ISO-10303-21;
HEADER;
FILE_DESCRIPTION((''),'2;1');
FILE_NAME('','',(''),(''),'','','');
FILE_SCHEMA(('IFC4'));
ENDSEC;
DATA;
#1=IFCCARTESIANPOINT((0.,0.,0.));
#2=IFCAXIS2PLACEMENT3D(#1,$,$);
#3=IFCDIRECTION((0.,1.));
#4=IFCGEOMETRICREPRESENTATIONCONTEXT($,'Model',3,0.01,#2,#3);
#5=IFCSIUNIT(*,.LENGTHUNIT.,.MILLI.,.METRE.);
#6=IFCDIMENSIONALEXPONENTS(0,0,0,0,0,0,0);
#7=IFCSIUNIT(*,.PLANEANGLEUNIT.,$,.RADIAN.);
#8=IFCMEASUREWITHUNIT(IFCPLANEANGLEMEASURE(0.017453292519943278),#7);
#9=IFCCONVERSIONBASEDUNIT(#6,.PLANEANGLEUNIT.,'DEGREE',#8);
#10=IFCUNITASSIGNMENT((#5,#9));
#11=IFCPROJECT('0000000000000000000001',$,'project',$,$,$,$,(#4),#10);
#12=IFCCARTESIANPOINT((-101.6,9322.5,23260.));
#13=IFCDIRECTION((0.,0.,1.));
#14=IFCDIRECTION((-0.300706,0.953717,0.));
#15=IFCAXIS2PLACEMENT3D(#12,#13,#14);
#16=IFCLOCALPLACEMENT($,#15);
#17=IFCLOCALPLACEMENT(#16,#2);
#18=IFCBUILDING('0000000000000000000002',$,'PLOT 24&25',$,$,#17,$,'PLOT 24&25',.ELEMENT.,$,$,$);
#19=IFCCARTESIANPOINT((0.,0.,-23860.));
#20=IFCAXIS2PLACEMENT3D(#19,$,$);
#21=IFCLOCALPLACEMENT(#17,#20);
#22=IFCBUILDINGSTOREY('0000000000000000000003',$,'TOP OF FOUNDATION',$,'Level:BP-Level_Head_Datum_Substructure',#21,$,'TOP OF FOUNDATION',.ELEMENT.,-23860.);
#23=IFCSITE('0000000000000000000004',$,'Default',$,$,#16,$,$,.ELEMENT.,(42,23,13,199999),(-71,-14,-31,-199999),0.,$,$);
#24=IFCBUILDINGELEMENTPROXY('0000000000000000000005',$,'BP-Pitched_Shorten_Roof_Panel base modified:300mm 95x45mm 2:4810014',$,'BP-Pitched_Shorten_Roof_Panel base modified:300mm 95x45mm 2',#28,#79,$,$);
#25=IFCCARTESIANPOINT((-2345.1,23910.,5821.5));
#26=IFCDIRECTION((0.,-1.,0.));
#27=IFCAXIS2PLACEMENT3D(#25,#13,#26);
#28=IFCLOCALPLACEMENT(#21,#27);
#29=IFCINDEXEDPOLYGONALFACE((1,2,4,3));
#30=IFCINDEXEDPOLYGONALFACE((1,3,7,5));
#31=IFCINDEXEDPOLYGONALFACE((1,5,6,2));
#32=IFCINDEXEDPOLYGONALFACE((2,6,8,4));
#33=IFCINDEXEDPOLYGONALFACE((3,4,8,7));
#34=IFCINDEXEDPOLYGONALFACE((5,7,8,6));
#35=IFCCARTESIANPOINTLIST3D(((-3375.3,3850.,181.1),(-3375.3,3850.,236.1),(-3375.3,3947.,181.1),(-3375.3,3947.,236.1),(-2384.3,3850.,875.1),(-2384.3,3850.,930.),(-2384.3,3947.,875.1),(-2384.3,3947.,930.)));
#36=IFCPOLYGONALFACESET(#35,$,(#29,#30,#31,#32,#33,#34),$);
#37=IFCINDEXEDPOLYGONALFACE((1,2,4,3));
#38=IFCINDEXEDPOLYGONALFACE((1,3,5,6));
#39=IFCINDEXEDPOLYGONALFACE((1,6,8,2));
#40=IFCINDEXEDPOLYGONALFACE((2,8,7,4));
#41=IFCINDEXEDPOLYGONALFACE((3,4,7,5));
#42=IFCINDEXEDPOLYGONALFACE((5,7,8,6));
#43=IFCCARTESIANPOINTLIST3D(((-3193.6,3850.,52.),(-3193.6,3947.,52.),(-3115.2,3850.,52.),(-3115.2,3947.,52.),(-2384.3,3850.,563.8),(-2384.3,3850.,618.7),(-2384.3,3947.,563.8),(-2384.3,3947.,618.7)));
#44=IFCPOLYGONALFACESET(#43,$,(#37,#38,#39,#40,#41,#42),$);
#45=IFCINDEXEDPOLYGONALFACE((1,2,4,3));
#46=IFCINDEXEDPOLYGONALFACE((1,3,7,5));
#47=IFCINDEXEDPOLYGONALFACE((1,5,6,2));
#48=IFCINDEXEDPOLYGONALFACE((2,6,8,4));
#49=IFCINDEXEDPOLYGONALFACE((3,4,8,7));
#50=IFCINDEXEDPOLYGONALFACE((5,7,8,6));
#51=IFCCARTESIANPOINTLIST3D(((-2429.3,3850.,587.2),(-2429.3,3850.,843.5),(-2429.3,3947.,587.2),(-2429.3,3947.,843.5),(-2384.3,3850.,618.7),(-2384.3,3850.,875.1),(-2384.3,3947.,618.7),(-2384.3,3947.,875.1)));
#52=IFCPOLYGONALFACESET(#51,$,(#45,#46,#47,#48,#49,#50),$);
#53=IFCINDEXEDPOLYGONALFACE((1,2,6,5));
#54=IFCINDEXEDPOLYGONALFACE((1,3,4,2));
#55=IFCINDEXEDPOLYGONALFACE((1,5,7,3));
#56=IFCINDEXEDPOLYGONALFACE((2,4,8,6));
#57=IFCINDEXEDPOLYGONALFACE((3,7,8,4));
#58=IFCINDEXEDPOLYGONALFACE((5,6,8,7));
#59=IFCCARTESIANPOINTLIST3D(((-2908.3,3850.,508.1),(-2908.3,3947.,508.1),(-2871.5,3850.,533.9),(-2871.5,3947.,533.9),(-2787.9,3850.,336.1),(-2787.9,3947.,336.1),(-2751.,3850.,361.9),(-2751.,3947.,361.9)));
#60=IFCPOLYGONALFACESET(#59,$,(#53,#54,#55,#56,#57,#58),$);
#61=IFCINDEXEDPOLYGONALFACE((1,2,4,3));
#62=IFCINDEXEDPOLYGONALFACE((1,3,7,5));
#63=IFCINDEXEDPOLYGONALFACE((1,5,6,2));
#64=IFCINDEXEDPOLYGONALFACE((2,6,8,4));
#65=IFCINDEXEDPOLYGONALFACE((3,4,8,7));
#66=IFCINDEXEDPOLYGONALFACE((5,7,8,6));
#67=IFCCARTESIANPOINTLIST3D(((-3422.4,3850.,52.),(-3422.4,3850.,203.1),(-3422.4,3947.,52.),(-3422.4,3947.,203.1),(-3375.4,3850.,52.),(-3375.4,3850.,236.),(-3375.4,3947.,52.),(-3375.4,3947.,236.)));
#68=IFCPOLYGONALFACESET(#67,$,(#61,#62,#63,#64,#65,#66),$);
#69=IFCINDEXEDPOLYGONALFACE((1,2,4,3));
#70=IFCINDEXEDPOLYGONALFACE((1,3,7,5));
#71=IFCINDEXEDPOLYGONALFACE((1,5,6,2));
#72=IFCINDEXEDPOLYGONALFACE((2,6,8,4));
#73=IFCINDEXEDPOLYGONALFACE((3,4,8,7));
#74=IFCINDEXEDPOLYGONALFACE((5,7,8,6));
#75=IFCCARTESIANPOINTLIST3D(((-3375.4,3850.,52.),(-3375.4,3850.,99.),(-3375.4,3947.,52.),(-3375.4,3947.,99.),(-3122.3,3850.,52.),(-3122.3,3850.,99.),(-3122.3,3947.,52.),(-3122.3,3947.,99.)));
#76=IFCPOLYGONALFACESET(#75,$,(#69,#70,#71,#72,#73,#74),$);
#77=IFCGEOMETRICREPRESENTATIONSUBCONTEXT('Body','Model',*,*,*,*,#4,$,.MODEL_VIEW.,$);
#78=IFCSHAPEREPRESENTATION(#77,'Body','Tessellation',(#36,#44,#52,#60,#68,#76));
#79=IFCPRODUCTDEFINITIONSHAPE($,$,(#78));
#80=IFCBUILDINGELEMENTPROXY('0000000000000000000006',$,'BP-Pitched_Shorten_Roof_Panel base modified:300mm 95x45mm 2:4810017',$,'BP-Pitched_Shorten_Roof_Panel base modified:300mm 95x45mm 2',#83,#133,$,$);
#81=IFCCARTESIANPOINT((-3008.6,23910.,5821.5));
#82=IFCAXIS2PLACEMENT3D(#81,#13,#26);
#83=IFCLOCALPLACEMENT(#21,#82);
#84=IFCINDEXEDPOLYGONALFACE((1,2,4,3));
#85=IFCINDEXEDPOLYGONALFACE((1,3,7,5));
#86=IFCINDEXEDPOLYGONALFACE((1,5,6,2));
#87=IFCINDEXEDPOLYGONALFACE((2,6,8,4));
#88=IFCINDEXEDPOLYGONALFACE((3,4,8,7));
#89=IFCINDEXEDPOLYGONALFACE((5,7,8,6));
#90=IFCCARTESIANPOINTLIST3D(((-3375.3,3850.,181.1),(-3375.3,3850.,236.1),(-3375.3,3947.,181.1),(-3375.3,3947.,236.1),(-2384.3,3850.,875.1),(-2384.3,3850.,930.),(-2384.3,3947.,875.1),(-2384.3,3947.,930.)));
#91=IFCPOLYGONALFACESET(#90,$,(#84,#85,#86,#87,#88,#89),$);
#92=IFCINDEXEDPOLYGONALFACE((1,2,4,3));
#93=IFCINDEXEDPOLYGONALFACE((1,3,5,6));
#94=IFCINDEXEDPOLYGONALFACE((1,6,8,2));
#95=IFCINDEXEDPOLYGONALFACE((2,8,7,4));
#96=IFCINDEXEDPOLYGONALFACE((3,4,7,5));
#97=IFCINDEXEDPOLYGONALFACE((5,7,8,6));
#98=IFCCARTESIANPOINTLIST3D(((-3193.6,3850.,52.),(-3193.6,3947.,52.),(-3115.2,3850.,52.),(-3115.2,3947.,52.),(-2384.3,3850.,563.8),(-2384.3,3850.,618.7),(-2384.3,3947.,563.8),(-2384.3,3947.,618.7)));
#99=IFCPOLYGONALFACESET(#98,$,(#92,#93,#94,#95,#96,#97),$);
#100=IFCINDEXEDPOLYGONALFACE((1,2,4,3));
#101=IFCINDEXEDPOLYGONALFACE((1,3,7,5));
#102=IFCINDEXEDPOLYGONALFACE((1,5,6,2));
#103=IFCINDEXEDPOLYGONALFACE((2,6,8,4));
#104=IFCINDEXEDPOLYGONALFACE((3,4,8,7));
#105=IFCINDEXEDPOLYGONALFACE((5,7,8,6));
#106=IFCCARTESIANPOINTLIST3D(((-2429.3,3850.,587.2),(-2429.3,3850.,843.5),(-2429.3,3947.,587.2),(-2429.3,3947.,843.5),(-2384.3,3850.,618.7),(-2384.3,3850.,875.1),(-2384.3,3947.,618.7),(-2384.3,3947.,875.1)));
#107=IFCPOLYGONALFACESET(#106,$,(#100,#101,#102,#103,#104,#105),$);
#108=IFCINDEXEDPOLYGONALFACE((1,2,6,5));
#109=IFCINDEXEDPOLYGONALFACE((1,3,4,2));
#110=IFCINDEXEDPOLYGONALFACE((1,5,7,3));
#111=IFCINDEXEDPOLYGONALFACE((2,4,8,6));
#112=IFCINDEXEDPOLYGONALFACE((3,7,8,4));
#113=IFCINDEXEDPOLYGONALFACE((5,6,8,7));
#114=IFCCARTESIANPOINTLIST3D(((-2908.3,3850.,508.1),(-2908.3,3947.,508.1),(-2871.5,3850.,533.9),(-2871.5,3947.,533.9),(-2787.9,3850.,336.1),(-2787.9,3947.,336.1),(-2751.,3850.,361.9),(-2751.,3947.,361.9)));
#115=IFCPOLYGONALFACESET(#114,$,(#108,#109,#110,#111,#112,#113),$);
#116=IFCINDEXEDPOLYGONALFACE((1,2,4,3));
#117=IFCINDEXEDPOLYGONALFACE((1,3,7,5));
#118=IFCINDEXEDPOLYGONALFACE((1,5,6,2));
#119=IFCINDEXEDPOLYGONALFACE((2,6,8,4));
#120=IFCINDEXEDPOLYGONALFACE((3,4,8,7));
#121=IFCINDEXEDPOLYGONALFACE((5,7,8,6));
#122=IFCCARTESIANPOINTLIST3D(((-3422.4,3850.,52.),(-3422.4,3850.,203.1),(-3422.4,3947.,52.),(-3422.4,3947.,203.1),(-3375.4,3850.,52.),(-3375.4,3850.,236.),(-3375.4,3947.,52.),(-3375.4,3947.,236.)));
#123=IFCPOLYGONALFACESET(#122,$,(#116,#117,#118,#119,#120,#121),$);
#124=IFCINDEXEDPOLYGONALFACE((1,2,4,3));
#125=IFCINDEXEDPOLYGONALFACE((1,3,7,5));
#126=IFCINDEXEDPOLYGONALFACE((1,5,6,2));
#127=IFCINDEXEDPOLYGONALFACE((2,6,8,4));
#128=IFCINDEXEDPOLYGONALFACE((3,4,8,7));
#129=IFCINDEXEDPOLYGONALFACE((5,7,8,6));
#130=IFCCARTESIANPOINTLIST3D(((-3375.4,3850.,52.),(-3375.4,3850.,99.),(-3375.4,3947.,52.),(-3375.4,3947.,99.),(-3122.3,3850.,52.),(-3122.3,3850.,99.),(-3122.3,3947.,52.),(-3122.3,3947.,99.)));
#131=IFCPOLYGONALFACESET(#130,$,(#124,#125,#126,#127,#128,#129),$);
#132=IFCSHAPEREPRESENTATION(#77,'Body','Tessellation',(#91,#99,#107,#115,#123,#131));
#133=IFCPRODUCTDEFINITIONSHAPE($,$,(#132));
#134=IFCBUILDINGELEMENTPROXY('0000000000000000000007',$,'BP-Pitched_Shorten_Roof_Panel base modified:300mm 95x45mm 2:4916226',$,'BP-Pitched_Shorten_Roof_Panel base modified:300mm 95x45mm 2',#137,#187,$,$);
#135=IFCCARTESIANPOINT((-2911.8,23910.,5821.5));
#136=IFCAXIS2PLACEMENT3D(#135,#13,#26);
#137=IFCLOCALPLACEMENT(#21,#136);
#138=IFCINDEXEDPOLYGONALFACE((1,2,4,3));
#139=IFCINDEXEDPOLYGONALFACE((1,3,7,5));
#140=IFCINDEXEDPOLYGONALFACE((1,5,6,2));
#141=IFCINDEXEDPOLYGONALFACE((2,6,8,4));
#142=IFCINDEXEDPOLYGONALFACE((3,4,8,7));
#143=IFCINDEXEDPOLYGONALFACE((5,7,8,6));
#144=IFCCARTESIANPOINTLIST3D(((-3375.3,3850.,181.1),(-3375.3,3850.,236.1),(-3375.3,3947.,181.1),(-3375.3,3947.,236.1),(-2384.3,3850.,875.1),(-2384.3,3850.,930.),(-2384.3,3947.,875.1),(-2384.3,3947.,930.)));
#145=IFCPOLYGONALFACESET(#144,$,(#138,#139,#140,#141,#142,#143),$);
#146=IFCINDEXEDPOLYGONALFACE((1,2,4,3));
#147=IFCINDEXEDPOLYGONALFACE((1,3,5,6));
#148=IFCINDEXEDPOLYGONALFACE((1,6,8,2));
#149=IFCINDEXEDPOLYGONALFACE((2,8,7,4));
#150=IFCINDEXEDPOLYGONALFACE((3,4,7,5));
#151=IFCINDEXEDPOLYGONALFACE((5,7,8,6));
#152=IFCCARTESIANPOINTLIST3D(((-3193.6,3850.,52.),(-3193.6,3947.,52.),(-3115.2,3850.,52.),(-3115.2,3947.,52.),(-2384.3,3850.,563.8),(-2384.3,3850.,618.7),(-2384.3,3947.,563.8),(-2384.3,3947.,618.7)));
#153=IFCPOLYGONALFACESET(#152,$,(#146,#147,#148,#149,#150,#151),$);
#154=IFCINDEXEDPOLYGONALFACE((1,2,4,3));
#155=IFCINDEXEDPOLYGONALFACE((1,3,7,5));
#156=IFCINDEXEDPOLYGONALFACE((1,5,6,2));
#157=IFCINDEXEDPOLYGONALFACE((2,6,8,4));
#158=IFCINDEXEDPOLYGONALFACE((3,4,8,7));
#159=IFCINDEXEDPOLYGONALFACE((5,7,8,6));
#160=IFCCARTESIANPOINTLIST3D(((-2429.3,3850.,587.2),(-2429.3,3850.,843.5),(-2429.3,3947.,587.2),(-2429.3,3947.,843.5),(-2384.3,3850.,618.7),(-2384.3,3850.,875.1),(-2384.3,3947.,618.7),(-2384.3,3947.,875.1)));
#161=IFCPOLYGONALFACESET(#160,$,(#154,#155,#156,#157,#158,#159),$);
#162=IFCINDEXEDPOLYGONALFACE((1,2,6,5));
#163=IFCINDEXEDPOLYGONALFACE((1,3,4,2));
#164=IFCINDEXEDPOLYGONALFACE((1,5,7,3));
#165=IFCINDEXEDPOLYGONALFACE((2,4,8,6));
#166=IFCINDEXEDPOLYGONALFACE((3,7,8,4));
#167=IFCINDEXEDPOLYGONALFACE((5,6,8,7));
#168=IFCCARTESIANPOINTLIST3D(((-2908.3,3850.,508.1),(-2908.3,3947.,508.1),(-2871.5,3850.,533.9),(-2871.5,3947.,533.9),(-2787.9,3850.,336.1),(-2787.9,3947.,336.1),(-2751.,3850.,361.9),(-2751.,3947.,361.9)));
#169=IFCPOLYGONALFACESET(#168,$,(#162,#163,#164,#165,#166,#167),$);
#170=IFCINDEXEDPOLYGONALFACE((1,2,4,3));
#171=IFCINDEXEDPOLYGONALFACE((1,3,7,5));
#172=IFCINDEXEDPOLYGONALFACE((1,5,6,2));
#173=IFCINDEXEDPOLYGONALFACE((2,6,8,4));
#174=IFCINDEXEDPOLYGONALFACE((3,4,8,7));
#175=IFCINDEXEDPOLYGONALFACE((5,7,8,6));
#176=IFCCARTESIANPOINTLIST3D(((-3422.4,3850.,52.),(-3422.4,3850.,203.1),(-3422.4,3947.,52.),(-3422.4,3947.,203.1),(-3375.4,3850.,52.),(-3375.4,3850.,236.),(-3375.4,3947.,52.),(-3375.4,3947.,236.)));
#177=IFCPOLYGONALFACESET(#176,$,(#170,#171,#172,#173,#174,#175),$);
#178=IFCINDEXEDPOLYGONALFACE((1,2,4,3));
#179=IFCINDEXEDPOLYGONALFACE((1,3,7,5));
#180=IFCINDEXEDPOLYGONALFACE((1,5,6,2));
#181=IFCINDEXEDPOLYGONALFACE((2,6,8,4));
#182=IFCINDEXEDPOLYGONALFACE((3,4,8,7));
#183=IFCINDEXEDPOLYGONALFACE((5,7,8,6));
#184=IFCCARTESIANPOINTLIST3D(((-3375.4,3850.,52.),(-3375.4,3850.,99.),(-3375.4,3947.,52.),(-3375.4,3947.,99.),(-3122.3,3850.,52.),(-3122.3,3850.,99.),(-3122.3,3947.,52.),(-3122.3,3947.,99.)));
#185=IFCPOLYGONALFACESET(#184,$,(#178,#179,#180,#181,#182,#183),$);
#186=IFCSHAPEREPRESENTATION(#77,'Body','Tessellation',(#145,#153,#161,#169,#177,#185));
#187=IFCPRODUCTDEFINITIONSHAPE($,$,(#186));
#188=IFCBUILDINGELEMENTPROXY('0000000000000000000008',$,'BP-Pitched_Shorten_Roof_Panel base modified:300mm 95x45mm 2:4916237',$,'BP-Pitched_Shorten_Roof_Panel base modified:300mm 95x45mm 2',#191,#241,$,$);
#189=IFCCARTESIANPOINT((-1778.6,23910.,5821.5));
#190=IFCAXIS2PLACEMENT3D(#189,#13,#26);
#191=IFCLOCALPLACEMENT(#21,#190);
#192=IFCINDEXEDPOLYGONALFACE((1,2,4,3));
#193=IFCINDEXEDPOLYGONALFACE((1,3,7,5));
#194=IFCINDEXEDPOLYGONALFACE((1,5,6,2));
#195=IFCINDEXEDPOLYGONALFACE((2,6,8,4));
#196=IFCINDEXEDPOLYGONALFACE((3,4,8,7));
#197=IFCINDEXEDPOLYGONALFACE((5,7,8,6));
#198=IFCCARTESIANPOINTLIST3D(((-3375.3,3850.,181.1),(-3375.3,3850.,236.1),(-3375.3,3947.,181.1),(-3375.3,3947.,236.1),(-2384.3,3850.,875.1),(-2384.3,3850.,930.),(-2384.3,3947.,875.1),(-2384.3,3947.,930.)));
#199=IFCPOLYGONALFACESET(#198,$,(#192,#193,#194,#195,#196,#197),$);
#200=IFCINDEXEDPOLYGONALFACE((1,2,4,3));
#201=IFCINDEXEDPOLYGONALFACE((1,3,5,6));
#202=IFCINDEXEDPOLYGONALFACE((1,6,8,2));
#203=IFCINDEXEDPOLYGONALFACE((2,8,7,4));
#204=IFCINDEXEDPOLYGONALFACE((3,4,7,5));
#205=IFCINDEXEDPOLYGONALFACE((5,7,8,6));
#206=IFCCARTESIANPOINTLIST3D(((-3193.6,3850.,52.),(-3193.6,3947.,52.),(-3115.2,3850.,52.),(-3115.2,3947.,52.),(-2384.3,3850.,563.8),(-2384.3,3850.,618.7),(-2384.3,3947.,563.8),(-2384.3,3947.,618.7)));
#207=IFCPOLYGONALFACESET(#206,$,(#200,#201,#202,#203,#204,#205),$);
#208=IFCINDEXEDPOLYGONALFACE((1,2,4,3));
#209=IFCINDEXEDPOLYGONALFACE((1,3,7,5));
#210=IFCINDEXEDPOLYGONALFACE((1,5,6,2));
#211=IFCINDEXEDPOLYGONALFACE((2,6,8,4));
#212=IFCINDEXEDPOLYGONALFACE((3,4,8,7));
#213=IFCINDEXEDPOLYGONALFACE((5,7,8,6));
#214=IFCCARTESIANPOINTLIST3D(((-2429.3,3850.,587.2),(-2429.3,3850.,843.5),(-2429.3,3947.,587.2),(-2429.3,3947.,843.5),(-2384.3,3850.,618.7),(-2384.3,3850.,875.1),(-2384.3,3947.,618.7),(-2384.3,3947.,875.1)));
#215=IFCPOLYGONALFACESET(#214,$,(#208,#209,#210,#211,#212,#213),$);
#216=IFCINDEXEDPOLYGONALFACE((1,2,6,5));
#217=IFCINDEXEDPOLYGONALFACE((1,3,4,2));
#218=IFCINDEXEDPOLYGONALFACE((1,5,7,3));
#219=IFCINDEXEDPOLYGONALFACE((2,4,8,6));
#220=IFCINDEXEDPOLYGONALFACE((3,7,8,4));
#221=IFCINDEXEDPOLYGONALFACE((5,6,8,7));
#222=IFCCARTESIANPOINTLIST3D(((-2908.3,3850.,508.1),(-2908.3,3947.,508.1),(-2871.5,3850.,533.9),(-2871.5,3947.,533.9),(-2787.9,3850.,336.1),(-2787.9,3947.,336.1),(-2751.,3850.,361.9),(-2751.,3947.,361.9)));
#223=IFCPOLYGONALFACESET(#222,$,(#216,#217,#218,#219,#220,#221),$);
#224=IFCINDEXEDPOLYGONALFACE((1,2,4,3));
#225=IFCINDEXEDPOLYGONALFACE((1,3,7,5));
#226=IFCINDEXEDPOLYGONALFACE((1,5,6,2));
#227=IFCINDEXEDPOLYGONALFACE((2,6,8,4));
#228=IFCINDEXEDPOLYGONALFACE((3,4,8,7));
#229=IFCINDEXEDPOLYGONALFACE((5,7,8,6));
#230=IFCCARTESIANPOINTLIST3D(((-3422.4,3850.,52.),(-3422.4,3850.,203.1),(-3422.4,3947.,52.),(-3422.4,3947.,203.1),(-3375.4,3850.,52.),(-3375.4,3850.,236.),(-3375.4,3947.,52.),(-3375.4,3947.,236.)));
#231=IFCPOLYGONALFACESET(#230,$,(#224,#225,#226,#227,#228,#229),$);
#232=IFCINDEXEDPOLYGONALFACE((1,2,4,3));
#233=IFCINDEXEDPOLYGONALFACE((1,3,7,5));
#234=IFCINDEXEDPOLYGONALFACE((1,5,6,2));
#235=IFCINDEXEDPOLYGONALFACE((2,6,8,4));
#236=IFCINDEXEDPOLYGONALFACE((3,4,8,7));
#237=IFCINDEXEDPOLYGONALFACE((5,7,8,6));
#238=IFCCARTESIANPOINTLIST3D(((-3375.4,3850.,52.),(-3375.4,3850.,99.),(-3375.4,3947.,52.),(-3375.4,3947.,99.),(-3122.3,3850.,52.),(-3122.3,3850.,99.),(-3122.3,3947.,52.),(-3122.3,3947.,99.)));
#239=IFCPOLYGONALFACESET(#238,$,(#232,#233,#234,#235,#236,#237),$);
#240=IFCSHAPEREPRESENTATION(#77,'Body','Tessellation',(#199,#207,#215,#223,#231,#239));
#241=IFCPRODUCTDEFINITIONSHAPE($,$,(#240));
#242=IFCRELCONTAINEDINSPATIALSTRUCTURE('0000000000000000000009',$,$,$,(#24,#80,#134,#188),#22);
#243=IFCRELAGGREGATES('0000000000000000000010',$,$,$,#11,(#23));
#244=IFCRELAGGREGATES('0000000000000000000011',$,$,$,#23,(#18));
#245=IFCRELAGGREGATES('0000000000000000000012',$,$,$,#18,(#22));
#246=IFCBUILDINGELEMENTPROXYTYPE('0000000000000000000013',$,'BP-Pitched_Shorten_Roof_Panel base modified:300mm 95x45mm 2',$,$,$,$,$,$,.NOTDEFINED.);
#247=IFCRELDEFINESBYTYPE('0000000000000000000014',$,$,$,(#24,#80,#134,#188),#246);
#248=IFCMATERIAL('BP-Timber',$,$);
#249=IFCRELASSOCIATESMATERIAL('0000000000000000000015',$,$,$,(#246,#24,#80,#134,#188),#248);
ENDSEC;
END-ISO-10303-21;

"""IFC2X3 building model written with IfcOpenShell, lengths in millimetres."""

from ifc_helpers import new_model, entity, si_unit, converted_unit, direction, frame, frame_2d, origin, place, context, subcontext, project, spatial, polyline, rectangle, outline, extrude, source, transform, mapped, material, type_object, type_shapes, element, save


model = new_model("IFC2X3")

# Units and contexts
model_context = context("Model", 3, precision=0.01, world=origin(), true_north=direction((0.0, 1.0)))
body_context = subcontext(model_context, "Body", "Model", "MODEL_VIEW")
ifc_project = project(units=[si_unit("LENGTHUNIT", "METRE", prefix="MILLI"), converted_unit("PLANEANGLEUNIT", "DEGREE", entity("IfcPlaneAngleMeasure", 0.017453292519943278), si_unit("PLANEANGLEUNIT", "RADIAN"), dimensions=[0, 0, 0, 0, 0, 0, 0])], contexts=[model_context])

# Site, building, storey
site_placement = place(None, frame((-101.6, 9322.5, 23260.0), z_axis=(0.0, 0.0, 1.0), x_axis=(-0.300706, 0.953717, 0.0)))
site = spatial("IfcSite", under=ifc_project, at=site_placement, Name="Default", CompositionType="ELEMENT", RefLatitude=(42, 23, 13, 199999), RefLongitude=(-71, -14, -31, -199999), RefElevation=0.0)
building_placement = place(site_placement, origin())
building = spatial("IfcBuilding", under=site, at=building_placement, Name="PLOT 24&25", LongName="PLOT 24&25", CompositionType="ELEMENT")
storey_placement = place(building_placement, frame((0.0, 0.0, -23860.0)))
storey = spatial("IfcBuildingStorey", under=building, at=storey_placement, Name="TOP OF FOUNDATION", ObjectType="Level:BP-Level_Head_Datum_Substructure", LongName="TOP OF FOUNDATION", CompositionType="ELEMENT", Elevation=-23860.0)

# Building element proxies
ifc_material_1 = material(Name="BP-Timber")
building_element_proxy_type_1 = type_object("IfcBuildingElementProxyType", Name="BP-Pitched_Shorten_Roof_Panel base modified:300mm 95x45mm 2", PredefinedType="NOTDEFINED", material=ifc_material_1)
shared_shape_1 = source(origin(), body_context, "Body", "SweptSolid", [
    extrude(outline(polyline([(-374.4, -495.5), (-319.5, -495.5), (374.4, 495.5), (319.5, 495.5), (-374.4, -495.5)])), frame((-2879.8, 3850.0, 555.6), z_axis=(0.0, 1.0, 0.0), x_axis=(0.0, 0.0, -1.0)), (0.0, 0.0, 1.0), 97.0),
    extrude(outline(polyline([(-297.1, -385.0), (-242.1, -385.0), (269.6, 345.8), (269.6, 424.3), (-297.1, -385.0)])), frame((-2769.4, 3850.0, 321.6), z_axis=(0.0, 1.0, 0.0), x_axis=(0.0, 0.0, -1.0)), (0.0, 0.0, 1.0), 97.0),
    extrude(outline(polyline([(46.1, -105.0), (101.0, -105.0), (-46.1, 105.0), (-101.0, 105.0), (46.1, -105.0)])), frame((-2406.8, 3850.0, 731.1), z_axis=(0.0, 1.0, 0.0), x_axis=(0.819152, 0.0, 0.573576)), (0.0, 0.0, 1.0), 97.0),
    extrude(rectangle(XDim=45.0, YDim=97.0, at=frame_2d((0.0, 0.0), x_axis=(0.0, 1.0))), frame((-2769.5, 3898.5, 349.0), z_axis=(-0.573576, 0.0, 0.819152), x_axis=(0.0, 1.0, 0.0)), (0.0, 0.0, 1.0), 210.0),
    extrude(outline(polyline([(-100.2, -23.5), (83.8, -23.5), (83.8, 23.5), (-67.3, 23.5), (-100.2, -23.5)])), frame((-3398.9, 3850.0, 135.8), z_axis=(0.0, 1.0, 0.0), x_axis=(0.0, 0.0, -1.0)), (0.0, 0.0, 1.0), 97.0),
    extrude(rectangle(XDim=97.0, YDim=253.1, at=frame_2d((0.0, 0.0), x_axis=(1.0, 0.0))), frame((-3248.9, 3898.5, 52.0), z_axis=(0.0, 0.0, 1.0), x_axis=(0.0, 1.0, 0.0)), (0.0, 0.0, 1.0), 47.0),
])
type_shapes(building_element_proxy_type_1, [shared_shape_1])
for number, where, z_axis, x_axis, name in (
    (1, (-2345.1, 23910.0, 5821.5), (0.0, 0.0, 1.0), (0.0, -1.0, 0.0), "BP-Pitched_Shorten_Roof_Panel base modified:300mm 95x45mm 2:4810014"),
    (2, (-3008.6, 23910.0, 5821.5), (0.0, 0.0, 1.0), (0.0, -1.0, 0.0), "BP-Pitched_Shorten_Roof_Panel base modified:300mm 95x45mm 2:4810017"),
    (3, (-2911.8, 23910.0, 5821.5), (0.0, 0.0, 1.0), (0.0, -1.0, 0.0), "BP-Pitched_Shorten_Roof_Panel base modified:300mm 95x45mm 2:4916226"),
    (4, (-1778.6, 23910.0, 5821.5), (0.0, 0.0, 1.0), (0.0, -1.0, 0.0), "BP-Pitched_Shorten_Roof_Panel base modified:300mm 95x45mm 2:4916237"),
):
    element("IfcBuildingElementProxy", number, at=place(storey_placement, frame(where, z_axis=z_axis, x_axis=x_axis)), inside=storey, type_object=building_element_proxy_type_1, material=ifc_material_1, Name=name, ObjectType="BP-Pitched_Shorten_Roof_Panel base modified:300mm 95x45mm 2", context=body_context, shape_type="MappedRepresentation", body=[
        mapped(shared_shape_1, transform((0.0, 0.0, 0.0), scale=1.0)),
    ])

save(model, "model.ifc")
